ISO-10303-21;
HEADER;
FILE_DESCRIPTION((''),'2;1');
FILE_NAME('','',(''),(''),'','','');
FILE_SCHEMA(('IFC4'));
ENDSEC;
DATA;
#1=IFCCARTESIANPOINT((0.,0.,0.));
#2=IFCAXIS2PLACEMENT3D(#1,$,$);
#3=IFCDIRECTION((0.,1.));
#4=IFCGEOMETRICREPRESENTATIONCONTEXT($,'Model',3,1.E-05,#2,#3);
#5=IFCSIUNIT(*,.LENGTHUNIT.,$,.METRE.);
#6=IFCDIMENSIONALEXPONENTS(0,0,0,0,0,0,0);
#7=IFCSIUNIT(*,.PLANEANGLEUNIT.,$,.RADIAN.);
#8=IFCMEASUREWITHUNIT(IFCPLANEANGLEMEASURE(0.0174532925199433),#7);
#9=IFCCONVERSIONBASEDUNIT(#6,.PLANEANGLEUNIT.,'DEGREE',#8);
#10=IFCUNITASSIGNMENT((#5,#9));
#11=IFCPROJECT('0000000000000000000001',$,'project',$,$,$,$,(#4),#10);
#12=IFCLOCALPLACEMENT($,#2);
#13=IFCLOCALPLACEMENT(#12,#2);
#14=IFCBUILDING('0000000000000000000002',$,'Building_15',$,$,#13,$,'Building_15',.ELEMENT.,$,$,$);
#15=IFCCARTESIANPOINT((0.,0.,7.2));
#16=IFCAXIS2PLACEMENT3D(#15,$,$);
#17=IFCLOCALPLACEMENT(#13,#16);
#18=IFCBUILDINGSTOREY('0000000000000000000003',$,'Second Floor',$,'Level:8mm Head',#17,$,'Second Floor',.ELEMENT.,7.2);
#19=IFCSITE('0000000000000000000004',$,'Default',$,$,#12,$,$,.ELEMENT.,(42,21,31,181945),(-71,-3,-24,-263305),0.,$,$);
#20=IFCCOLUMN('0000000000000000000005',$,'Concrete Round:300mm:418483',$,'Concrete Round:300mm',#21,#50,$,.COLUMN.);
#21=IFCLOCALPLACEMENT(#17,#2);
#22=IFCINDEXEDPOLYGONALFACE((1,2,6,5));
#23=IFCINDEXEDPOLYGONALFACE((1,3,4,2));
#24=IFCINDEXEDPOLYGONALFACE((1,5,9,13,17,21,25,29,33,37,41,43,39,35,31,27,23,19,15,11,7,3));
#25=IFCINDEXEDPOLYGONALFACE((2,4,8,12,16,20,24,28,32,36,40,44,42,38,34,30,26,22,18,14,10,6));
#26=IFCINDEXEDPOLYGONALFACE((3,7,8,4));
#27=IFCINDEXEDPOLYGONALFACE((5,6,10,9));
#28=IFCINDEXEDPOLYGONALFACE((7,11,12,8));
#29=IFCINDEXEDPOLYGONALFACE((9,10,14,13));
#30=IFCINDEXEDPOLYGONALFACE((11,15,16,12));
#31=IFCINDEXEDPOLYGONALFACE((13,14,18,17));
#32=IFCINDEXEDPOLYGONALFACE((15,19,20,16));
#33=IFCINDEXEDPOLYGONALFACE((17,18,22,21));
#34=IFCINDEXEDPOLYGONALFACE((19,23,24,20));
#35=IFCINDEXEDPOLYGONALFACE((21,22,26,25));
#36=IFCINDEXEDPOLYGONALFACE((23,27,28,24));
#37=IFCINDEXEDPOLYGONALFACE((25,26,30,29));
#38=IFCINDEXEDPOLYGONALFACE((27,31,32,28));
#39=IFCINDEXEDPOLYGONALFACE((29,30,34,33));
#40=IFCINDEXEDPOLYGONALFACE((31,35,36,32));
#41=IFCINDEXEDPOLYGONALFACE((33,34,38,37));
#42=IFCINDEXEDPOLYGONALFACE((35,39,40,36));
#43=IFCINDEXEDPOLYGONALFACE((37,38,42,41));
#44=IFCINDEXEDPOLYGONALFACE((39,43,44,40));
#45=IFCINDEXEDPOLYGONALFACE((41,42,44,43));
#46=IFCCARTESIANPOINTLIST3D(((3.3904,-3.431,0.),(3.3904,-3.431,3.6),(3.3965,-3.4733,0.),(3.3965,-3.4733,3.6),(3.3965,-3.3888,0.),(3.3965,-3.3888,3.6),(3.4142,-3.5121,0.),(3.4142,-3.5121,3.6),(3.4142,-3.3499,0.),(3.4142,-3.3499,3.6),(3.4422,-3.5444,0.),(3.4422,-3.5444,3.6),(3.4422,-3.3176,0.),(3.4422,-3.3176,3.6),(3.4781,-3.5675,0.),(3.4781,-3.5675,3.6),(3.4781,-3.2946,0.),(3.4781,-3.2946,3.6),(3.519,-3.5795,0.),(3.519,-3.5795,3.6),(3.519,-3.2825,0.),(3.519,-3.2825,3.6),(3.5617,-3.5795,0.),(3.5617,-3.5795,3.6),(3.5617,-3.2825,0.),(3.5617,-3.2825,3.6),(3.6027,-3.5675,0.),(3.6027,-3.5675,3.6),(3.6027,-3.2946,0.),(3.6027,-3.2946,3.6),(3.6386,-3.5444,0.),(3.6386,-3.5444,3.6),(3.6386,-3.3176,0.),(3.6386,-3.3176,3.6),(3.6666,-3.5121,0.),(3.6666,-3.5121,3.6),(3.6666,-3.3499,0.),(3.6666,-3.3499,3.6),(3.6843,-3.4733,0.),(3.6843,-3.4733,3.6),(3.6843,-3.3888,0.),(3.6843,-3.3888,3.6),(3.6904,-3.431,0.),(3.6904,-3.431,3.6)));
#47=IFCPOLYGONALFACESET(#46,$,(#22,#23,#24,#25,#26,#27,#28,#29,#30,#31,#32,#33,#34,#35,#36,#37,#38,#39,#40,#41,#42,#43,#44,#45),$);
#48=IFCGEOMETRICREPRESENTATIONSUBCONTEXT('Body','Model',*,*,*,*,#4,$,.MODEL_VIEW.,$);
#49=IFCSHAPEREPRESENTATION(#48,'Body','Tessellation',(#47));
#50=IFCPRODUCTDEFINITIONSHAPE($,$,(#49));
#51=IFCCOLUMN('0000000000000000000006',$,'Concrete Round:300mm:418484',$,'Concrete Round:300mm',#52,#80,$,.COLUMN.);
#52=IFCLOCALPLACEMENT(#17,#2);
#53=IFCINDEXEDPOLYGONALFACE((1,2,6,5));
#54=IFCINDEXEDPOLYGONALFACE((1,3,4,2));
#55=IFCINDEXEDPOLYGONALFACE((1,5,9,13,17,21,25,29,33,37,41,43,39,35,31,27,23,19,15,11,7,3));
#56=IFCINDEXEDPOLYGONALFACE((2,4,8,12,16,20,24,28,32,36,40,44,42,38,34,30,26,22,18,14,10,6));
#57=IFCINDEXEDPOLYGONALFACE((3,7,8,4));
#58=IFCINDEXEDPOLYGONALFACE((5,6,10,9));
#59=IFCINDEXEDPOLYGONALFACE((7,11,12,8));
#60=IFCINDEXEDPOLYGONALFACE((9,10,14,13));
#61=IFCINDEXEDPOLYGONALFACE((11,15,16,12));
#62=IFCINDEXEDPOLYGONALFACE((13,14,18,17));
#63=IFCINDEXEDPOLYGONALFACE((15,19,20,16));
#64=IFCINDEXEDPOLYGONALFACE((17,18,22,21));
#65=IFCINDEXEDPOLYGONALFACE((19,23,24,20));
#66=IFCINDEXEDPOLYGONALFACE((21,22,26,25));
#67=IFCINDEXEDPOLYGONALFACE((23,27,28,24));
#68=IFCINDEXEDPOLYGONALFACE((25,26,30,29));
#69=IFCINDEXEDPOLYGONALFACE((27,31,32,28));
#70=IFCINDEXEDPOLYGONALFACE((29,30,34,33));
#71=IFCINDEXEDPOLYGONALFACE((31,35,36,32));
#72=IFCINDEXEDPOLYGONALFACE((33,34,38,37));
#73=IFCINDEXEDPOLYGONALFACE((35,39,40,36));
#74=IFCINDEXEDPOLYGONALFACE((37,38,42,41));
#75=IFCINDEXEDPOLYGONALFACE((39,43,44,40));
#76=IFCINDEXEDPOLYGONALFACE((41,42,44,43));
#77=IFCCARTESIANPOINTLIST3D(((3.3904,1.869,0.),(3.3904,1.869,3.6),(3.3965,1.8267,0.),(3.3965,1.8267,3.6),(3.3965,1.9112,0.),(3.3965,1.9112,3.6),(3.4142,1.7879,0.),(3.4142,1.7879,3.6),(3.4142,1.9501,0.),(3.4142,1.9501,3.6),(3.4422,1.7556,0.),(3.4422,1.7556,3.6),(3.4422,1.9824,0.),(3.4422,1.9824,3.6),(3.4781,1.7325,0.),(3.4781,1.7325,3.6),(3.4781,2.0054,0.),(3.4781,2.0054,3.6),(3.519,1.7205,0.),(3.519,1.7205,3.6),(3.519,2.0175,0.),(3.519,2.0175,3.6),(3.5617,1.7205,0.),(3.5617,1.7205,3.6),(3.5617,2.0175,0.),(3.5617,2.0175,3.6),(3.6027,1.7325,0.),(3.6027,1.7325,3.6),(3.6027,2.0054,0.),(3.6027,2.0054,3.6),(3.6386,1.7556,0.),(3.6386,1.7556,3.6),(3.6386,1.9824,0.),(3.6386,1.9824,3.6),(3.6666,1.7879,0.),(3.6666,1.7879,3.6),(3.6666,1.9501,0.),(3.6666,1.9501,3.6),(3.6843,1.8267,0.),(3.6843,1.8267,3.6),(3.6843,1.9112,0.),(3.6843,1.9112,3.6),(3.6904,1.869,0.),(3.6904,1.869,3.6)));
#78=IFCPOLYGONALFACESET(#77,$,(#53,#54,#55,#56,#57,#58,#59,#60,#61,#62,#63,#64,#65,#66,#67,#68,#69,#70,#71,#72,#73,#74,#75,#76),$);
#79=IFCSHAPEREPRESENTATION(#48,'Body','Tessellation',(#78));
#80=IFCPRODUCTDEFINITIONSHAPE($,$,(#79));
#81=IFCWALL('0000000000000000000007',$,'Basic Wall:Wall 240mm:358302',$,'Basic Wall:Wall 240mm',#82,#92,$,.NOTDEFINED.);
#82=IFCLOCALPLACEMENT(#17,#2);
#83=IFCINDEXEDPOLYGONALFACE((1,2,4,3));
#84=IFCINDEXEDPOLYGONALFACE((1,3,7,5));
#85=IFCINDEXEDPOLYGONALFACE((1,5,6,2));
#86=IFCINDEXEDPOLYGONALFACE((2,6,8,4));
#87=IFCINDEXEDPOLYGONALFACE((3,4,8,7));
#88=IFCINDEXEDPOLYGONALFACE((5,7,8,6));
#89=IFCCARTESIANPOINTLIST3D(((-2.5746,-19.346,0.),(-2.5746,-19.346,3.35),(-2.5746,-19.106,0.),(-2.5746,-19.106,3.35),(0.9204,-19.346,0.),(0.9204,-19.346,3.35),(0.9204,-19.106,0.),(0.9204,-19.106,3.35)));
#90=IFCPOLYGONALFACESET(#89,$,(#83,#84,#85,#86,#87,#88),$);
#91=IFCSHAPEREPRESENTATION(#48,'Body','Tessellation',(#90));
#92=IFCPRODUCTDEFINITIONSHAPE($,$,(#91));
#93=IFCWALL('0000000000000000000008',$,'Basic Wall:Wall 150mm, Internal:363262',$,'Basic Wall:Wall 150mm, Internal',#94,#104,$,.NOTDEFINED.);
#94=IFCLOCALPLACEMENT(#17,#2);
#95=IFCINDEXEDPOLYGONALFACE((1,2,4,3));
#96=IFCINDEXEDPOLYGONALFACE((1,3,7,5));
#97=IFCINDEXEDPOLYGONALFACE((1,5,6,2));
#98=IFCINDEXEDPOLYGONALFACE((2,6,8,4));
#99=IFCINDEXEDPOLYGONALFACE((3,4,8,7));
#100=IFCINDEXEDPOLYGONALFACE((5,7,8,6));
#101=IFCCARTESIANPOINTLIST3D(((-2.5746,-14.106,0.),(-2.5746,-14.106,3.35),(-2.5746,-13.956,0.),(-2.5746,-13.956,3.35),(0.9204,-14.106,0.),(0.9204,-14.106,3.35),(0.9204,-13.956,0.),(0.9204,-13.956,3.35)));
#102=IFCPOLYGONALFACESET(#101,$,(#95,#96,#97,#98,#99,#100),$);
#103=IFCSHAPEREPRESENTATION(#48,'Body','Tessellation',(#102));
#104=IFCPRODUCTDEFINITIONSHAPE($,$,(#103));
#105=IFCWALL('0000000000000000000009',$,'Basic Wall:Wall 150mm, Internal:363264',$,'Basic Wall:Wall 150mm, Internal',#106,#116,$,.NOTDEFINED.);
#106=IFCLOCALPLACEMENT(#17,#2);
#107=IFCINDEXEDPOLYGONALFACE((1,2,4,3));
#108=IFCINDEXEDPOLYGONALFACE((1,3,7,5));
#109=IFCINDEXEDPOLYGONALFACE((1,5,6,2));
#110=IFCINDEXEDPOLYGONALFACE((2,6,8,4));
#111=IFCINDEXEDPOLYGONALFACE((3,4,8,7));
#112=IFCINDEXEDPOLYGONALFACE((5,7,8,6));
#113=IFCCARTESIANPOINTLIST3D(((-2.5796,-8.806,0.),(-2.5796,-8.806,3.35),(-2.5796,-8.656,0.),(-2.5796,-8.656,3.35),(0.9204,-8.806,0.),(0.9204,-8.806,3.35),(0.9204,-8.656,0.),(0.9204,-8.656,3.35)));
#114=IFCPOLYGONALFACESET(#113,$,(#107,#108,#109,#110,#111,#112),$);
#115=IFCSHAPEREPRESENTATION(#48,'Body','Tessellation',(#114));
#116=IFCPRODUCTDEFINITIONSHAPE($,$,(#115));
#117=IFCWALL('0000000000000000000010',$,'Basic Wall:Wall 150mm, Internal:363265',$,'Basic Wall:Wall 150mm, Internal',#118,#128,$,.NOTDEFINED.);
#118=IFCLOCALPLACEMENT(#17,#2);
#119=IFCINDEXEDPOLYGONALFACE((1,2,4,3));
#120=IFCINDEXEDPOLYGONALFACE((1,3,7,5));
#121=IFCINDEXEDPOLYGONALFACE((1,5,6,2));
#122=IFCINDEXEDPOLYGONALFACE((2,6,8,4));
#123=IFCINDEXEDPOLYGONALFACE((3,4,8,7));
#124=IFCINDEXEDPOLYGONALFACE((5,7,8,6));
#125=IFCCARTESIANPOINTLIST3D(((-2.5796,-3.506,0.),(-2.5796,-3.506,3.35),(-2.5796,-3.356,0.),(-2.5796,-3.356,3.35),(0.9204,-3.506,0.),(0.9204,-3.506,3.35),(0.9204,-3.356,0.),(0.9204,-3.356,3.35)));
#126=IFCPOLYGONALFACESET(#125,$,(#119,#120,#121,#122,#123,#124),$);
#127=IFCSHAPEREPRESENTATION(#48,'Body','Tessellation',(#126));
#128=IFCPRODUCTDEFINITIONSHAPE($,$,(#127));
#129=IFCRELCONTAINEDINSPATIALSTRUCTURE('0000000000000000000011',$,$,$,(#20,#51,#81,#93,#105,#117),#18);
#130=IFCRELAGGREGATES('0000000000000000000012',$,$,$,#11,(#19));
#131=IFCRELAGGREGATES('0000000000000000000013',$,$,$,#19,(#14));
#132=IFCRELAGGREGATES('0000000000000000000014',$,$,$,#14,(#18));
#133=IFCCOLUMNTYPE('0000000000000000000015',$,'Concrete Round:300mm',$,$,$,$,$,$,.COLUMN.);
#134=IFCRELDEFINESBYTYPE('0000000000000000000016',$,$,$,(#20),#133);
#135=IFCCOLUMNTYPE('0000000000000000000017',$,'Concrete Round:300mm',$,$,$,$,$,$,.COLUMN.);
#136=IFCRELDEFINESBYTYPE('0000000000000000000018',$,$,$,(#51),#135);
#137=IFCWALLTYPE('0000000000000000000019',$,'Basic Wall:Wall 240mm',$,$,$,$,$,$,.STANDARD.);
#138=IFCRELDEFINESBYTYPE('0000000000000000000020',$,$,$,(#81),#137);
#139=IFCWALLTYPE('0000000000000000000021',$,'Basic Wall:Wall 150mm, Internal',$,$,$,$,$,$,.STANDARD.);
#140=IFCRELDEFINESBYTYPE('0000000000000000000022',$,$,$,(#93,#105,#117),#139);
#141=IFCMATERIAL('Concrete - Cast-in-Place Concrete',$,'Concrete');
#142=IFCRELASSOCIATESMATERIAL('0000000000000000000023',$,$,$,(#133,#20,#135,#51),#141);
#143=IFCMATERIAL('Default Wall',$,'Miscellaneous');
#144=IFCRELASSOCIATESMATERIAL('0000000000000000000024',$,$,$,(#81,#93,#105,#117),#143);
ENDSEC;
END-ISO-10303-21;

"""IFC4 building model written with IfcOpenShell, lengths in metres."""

from ifc_helpers import new_model, entity, si_unit, converted_unit, direction, frame, origin, place, context, subcontext, project, spatial, arc, indexed_curve, outline, extrude, source, transform, mapped, material, type_object, type_shapes, element, save


model = new_model("IFC4")

# Units and contexts
model_context = context("Model", 3, precision=1e-05, world=origin(), true_north=direction((0.0, 1.0)))
body_context = subcontext(model_context, "Body", "Model", "MODEL_VIEW")
ifc_project = project(units=[si_unit("LENGTHUNIT", "METRE"), converted_unit("PLANEANGLEUNIT", "DEGREE", entity("IfcPlaneAngleMeasure", 0.0174532925199433), si_unit("PLANEANGLEUNIT", "RADIAN"), dimensions=[0, 0, 0, 0, 0, 0, 0])], contexts=[model_context])

# Site, building, storey
site_placement = place(None, origin())
site = spatial("IfcSite", under=ifc_project, at=site_placement, Name="Default", CompositionType="ELEMENT", RefLatitude=(42, 21, 31, 181945), RefLongitude=(-71, -3, -24, -263305), RefElevation=0.0)
building_placement = place(site_placement, origin())
building = spatial("IfcBuilding", under=site, at=building_placement, Name="Building_15", LongName="Building_15", CompositionType="ELEMENT")
storey_placement = place(building_placement, frame((0.0, 0.0, 7.2)))
storey = spatial("IfcBuildingStorey", under=building, at=storey_placement, Name="Second Floor", ObjectType="Level:8mm Head", LongName="Second Floor", CompositionType="ELEMENT", Elevation=7.2)

# Columns
ifc_material_1 = material(Name="Concrete - Cast-in-Place Concrete", Category="Concrete")
column_type_1 = type_object("IfcColumnType", Name="Concrete Round:300mm", PredefinedType="COLUMN", material=ifc_material_1)
shared_shape_1 = source(origin(), body_context, "Body", "SweptSolid", [
    extrude(outline(indexed_curve([(-0.15, 0.0), (0.0, -0.15), (0.15, 0.0), (0.0, 0.15)], segments=[arc(1, 2, 3), arc(3, 4, 1)], self_intersect=False)), frame((3.5404, -3.431, 7.2)), (0.0, 0.0, 1.0), 3.6),
])
type_shapes(column_type_1, [shared_shape_1])
column_1_placement = place(storey_placement, frame((0.0, 0.0, -7.2)))
element("IfcColumn", 1, at=column_1_placement, inside=storey, type_object=column_type_1, material=ifc_material_1, Name="Concrete Round:300mm:418483", ObjectType="Concrete Round:300mm", PredefinedType="COLUMN", context=body_context, shape_type="MappedRepresentation", body=[
    mapped(shared_shape_1, transform((0.0, 0.0, 0.0), scale=1.0)),
])
column_type_2 = type_object("IfcColumnType", Name="Concrete Round:300mm", PredefinedType="COLUMN", material=ifc_material_1)
shared_shape_2 = source(origin(), body_context, "Body", "SweptSolid", [
    extrude(outline(indexed_curve([(-0.15, 0.0), (0.0, -0.15), (0.15, 0.0), (0.0, 0.15)], segments=[arc(1, 2, 3), arc(3, 4, 1)], self_intersect=False)), frame((3.5404, 1.869, 7.2)), (0.0, 0.0, 1.0), 3.6),
])
type_shapes(column_type_2, [shared_shape_2])
column_2_placement = place(storey_placement, frame((0.0, 0.0, -7.2)))
element("IfcColumn", 2, at=column_2_placement, inside=storey, type_object=column_type_2, material=ifc_material_1, Name="Concrete Round:300mm:418484", ObjectType="Concrete Round:300mm", PredefinedType="COLUMN", context=body_context, shape_type="MappedRepresentation", body=[
    mapped(shared_shape_2, transform((0.0, 0.0, 0.0), scale=1.0)),
])

# Walls
ifc_material_2 = material(Name="Default Wall", Category="Miscellaneous")
wall_type_1 = type_object("IfcWallType", Name="Basic Wall:Wall 240mm", PredefinedType="STANDARD")
wall_1_placement = place(storey_placement, frame((0.9204, -19.226, 0.0), z_axis=(0.0, 0.0, 1.0), x_axis=(-1.0, 0.0, 0.0)))
element("IfcWall", 3, at=wall_1_placement, inside=storey, type_object=wall_type_1, material=ifc_material_2, Name="Basic Wall:Wall 240mm:358302", ObjectType="Basic Wall:Wall 240mm", PredefinedType="NOTDEFINED", context=body_context, shape_type="SweptSolid", body=[
    extrude(outline(indexed_curve([(3.495, 0.12), (0.0, 0.12), (0.0, -0.12), (3.495, -0.12), (3.495, 0.12)], self_intersect=False)), origin(), (0.0, 0.0, 1.0), 3.35),
])
wall_type_2 = type_object("IfcWallType", Name="Basic Wall:Wall 150mm, Internal", PredefinedType="STANDARD")
wall_2_placement = place(storey_placement, frame((-2.5746, -14.031, 0.0)))
element("IfcWall", 4, at=wall_2_placement, inside=storey, type_object=wall_type_2, material=ifc_material_2, Name="Basic Wall:Wall 150mm, Internal:363262", ObjectType="Basic Wall:Wall 150mm, Internal", PredefinedType="NOTDEFINED", context=body_context, shape_type="SweptSolid", body=[
    extrude(outline(indexed_curve([(3.495, 0.075), (0.0, 0.075), (0.0, -0.075), (3.495, -0.075), (3.495, 0.075)], self_intersect=False)), origin(), (0.0, 0.0, 1.0), 3.35),
])
wall_3_placement = place(storey_placement, frame((0.9204, -8.731, 0.0), z_axis=(0.0, 0.0, 1.0), x_axis=(-1.0, 0.0, 0.0)))
element("IfcWall", 5, at=wall_3_placement, inside=storey, type_object=wall_type_2, material=ifc_material_2, Name="Basic Wall:Wall 150mm, Internal:363264", ObjectType="Basic Wall:Wall 150mm, Internal", PredefinedType="NOTDEFINED", context=body_context, shape_type="SweptSolid", body=[
    extrude(outline(indexed_curve([(3.5, 0.075), (0.0, 0.075), (0.0, -0.075), (3.5, -0.075), (3.5, 0.075)], self_intersect=False)), origin(), (0.0, 0.0, 1.0), 3.35),
])
wall_4_placement = place(storey_placement, frame((0.9204, -3.431, 0.0), z_axis=(0.0, 0.0, 1.0), x_axis=(-1.0, 0.0, 0.0)))
element("IfcWall", 6, at=wall_4_placement, inside=storey, type_object=wall_type_2, material=ifc_material_2, Name="Basic Wall:Wall 150mm, Internal:363265", ObjectType="Basic Wall:Wall 150mm, Internal", PredefinedType="NOTDEFINED", context=body_context, shape_type="SweptSolid", body=[
    extrude(outline(indexed_curve([(3.5, 0.075), (0.0, 0.075), (0.0, -0.075), (3.5, -0.075), (3.5, 0.075)], self_intersect=False)), origin(), (0.0, 0.0, 1.0), 3.35),
])

save(model, "model.ifc")
